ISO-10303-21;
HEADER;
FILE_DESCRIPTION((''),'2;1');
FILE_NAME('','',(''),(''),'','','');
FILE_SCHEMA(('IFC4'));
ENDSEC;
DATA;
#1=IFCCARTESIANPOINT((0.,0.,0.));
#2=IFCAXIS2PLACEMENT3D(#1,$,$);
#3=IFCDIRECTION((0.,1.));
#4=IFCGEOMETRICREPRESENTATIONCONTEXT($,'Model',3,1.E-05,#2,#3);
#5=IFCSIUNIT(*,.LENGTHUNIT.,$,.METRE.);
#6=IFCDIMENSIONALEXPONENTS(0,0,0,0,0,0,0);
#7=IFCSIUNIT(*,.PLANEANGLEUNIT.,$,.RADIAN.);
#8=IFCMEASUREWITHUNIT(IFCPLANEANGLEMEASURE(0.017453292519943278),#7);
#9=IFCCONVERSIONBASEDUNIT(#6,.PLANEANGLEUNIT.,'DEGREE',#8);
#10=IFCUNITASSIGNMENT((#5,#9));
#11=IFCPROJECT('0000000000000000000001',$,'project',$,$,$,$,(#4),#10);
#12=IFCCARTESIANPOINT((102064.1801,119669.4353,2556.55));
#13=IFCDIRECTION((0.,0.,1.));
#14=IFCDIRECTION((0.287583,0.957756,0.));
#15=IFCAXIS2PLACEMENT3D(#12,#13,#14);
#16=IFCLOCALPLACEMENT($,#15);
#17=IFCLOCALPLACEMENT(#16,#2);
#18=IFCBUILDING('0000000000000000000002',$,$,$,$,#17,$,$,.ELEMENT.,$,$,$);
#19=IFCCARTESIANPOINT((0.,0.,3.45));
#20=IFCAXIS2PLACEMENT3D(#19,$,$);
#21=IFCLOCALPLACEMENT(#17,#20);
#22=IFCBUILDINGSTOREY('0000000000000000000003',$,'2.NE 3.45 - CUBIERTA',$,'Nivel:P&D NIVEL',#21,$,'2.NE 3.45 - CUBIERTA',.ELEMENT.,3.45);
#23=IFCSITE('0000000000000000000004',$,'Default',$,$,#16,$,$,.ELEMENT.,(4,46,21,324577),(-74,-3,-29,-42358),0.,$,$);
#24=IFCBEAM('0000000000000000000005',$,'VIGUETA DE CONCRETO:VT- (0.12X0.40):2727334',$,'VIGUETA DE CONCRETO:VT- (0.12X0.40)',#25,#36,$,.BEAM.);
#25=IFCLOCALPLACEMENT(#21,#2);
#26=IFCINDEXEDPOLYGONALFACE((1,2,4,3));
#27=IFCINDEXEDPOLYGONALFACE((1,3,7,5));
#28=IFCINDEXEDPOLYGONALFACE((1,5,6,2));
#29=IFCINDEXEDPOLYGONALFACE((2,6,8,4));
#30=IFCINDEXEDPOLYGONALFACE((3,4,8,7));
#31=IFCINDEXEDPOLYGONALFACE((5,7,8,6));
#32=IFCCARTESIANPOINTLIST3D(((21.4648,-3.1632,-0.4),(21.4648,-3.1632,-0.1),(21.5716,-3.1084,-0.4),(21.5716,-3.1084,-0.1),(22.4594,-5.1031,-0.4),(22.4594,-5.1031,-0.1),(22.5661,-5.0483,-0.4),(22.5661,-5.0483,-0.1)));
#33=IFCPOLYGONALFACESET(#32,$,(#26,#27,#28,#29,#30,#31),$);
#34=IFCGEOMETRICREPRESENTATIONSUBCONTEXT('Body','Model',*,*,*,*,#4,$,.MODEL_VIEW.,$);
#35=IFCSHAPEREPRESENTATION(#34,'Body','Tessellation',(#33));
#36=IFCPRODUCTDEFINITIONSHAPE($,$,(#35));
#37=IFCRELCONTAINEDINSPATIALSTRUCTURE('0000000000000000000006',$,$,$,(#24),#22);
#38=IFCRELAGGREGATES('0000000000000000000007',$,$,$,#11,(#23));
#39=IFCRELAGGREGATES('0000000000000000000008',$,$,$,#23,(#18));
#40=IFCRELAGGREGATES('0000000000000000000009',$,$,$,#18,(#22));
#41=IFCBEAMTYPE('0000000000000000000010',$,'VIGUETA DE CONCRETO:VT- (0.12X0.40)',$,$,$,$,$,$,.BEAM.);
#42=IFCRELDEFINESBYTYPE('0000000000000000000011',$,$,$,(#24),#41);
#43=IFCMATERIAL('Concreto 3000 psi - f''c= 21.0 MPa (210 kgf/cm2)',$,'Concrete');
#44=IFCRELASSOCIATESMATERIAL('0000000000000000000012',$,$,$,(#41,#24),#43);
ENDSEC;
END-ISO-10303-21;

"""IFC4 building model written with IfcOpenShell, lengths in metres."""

from ifc_helpers import new_model, entity, si_unit, converted_unit, direction, frame, origin, place, context, subcontext, project, spatial, indexed_curve, outline, extrude, source, transform, mapped, material, type_object, type_shapes, element, save


model = new_model("IFC4")

# Units and contexts
model_context = context("Model", 3, precision=1e-05, world=origin(), true_north=direction((0.0, 1.0)))
body_context = subcontext(model_context, "Body", "Model", "MODEL_VIEW")
ifc_project = project(units=[si_unit("LENGTHUNIT", "METRE"), converted_unit("PLANEANGLEUNIT", "DEGREE", entity("IfcPlaneAngleMeasure", 0.017453292519943278), si_unit("PLANEANGLEUNIT", "RADIAN"), dimensions=[0, 0, 0, 0, 0, 0, 0])], contexts=[model_context])

# Site, building, storey
site_placement = place(None, frame((102064.1801, 119669.4353, 2556.55), z_axis=(0.0, 0.0, 1.0), x_axis=(0.287583, 0.957756, 0.0)))
site = spatial("IfcSite", under=ifc_project, at=site_placement, Name="Default", CompositionType="ELEMENT", RefLatitude=(4, 46, 21, 324577), RefLongitude=(-74, -3, -29, -42358), RefElevation=0.0)
building_placement = place(site_placement, origin())
building = spatial("IfcBuilding", under=site, at=building_placement, CompositionType="ELEMENT")
storey_placement = place(building_placement, frame((0.0, 0.0, 3.45)))
storey = spatial("IfcBuildingStorey", under=building, at=storey_placement, Name="2.NE 3.45 - CUBIERTA", ObjectType="Nivel:P&D NIVEL", LongName="2.NE 3.45 - CUBIERTA", CompositionType="ELEMENT", Elevation=3.45)

# Beam
ifc_material_1 = material(Name="Concreto 3000 psi - f'c= 21.0 MPa (210 kgf/cm2)", Category="Concrete")
beam_type_1 = type_object("IfcBeamType", Name="VIGUETA DE CONCRETO:VT- (0.12X0.40)", PredefinedType="BEAM", material=ifc_material_1)
shared_shape_1 = source(origin(), body_context, "Body", "SweptSolid", [
    extrude(outline(indexed_curve([(-0.15, -0.06), (0.15, -0.06), (0.15, 0.06), (-0.15, 0.06), (-0.15, -0.06)], self_intersect=False)), frame((21.5182, -3.1358, 3.2), z_axis=(0.456217, -0.889869, 0.0), x_axis=(0.0, 0.0, -1.0)), (0.0, 0.0, 1.0), 2.18),
])
type_shapes(beam_type_1, [shared_shape_1])
beam_1_placement = place(storey_placement, frame((0.0, 0.0, -3.45)))
element("IfcBeam", 1, at=beam_1_placement, inside=storey, type_object=beam_type_1, material=ifc_material_1, Name="VIGUETA DE CONCRETO:VT- (0.12X0.40):2727334", ObjectType="VIGUETA DE CONCRETO:VT- (0.12X0.40)", PredefinedType="BEAM", context=body_context, shape_type="MappedRepresentation", body=[
    mapped(shared_shape_1, transform((0.0, 0.0, 0.0), scale=1.0)),
])

save(model, "model.ifc")
